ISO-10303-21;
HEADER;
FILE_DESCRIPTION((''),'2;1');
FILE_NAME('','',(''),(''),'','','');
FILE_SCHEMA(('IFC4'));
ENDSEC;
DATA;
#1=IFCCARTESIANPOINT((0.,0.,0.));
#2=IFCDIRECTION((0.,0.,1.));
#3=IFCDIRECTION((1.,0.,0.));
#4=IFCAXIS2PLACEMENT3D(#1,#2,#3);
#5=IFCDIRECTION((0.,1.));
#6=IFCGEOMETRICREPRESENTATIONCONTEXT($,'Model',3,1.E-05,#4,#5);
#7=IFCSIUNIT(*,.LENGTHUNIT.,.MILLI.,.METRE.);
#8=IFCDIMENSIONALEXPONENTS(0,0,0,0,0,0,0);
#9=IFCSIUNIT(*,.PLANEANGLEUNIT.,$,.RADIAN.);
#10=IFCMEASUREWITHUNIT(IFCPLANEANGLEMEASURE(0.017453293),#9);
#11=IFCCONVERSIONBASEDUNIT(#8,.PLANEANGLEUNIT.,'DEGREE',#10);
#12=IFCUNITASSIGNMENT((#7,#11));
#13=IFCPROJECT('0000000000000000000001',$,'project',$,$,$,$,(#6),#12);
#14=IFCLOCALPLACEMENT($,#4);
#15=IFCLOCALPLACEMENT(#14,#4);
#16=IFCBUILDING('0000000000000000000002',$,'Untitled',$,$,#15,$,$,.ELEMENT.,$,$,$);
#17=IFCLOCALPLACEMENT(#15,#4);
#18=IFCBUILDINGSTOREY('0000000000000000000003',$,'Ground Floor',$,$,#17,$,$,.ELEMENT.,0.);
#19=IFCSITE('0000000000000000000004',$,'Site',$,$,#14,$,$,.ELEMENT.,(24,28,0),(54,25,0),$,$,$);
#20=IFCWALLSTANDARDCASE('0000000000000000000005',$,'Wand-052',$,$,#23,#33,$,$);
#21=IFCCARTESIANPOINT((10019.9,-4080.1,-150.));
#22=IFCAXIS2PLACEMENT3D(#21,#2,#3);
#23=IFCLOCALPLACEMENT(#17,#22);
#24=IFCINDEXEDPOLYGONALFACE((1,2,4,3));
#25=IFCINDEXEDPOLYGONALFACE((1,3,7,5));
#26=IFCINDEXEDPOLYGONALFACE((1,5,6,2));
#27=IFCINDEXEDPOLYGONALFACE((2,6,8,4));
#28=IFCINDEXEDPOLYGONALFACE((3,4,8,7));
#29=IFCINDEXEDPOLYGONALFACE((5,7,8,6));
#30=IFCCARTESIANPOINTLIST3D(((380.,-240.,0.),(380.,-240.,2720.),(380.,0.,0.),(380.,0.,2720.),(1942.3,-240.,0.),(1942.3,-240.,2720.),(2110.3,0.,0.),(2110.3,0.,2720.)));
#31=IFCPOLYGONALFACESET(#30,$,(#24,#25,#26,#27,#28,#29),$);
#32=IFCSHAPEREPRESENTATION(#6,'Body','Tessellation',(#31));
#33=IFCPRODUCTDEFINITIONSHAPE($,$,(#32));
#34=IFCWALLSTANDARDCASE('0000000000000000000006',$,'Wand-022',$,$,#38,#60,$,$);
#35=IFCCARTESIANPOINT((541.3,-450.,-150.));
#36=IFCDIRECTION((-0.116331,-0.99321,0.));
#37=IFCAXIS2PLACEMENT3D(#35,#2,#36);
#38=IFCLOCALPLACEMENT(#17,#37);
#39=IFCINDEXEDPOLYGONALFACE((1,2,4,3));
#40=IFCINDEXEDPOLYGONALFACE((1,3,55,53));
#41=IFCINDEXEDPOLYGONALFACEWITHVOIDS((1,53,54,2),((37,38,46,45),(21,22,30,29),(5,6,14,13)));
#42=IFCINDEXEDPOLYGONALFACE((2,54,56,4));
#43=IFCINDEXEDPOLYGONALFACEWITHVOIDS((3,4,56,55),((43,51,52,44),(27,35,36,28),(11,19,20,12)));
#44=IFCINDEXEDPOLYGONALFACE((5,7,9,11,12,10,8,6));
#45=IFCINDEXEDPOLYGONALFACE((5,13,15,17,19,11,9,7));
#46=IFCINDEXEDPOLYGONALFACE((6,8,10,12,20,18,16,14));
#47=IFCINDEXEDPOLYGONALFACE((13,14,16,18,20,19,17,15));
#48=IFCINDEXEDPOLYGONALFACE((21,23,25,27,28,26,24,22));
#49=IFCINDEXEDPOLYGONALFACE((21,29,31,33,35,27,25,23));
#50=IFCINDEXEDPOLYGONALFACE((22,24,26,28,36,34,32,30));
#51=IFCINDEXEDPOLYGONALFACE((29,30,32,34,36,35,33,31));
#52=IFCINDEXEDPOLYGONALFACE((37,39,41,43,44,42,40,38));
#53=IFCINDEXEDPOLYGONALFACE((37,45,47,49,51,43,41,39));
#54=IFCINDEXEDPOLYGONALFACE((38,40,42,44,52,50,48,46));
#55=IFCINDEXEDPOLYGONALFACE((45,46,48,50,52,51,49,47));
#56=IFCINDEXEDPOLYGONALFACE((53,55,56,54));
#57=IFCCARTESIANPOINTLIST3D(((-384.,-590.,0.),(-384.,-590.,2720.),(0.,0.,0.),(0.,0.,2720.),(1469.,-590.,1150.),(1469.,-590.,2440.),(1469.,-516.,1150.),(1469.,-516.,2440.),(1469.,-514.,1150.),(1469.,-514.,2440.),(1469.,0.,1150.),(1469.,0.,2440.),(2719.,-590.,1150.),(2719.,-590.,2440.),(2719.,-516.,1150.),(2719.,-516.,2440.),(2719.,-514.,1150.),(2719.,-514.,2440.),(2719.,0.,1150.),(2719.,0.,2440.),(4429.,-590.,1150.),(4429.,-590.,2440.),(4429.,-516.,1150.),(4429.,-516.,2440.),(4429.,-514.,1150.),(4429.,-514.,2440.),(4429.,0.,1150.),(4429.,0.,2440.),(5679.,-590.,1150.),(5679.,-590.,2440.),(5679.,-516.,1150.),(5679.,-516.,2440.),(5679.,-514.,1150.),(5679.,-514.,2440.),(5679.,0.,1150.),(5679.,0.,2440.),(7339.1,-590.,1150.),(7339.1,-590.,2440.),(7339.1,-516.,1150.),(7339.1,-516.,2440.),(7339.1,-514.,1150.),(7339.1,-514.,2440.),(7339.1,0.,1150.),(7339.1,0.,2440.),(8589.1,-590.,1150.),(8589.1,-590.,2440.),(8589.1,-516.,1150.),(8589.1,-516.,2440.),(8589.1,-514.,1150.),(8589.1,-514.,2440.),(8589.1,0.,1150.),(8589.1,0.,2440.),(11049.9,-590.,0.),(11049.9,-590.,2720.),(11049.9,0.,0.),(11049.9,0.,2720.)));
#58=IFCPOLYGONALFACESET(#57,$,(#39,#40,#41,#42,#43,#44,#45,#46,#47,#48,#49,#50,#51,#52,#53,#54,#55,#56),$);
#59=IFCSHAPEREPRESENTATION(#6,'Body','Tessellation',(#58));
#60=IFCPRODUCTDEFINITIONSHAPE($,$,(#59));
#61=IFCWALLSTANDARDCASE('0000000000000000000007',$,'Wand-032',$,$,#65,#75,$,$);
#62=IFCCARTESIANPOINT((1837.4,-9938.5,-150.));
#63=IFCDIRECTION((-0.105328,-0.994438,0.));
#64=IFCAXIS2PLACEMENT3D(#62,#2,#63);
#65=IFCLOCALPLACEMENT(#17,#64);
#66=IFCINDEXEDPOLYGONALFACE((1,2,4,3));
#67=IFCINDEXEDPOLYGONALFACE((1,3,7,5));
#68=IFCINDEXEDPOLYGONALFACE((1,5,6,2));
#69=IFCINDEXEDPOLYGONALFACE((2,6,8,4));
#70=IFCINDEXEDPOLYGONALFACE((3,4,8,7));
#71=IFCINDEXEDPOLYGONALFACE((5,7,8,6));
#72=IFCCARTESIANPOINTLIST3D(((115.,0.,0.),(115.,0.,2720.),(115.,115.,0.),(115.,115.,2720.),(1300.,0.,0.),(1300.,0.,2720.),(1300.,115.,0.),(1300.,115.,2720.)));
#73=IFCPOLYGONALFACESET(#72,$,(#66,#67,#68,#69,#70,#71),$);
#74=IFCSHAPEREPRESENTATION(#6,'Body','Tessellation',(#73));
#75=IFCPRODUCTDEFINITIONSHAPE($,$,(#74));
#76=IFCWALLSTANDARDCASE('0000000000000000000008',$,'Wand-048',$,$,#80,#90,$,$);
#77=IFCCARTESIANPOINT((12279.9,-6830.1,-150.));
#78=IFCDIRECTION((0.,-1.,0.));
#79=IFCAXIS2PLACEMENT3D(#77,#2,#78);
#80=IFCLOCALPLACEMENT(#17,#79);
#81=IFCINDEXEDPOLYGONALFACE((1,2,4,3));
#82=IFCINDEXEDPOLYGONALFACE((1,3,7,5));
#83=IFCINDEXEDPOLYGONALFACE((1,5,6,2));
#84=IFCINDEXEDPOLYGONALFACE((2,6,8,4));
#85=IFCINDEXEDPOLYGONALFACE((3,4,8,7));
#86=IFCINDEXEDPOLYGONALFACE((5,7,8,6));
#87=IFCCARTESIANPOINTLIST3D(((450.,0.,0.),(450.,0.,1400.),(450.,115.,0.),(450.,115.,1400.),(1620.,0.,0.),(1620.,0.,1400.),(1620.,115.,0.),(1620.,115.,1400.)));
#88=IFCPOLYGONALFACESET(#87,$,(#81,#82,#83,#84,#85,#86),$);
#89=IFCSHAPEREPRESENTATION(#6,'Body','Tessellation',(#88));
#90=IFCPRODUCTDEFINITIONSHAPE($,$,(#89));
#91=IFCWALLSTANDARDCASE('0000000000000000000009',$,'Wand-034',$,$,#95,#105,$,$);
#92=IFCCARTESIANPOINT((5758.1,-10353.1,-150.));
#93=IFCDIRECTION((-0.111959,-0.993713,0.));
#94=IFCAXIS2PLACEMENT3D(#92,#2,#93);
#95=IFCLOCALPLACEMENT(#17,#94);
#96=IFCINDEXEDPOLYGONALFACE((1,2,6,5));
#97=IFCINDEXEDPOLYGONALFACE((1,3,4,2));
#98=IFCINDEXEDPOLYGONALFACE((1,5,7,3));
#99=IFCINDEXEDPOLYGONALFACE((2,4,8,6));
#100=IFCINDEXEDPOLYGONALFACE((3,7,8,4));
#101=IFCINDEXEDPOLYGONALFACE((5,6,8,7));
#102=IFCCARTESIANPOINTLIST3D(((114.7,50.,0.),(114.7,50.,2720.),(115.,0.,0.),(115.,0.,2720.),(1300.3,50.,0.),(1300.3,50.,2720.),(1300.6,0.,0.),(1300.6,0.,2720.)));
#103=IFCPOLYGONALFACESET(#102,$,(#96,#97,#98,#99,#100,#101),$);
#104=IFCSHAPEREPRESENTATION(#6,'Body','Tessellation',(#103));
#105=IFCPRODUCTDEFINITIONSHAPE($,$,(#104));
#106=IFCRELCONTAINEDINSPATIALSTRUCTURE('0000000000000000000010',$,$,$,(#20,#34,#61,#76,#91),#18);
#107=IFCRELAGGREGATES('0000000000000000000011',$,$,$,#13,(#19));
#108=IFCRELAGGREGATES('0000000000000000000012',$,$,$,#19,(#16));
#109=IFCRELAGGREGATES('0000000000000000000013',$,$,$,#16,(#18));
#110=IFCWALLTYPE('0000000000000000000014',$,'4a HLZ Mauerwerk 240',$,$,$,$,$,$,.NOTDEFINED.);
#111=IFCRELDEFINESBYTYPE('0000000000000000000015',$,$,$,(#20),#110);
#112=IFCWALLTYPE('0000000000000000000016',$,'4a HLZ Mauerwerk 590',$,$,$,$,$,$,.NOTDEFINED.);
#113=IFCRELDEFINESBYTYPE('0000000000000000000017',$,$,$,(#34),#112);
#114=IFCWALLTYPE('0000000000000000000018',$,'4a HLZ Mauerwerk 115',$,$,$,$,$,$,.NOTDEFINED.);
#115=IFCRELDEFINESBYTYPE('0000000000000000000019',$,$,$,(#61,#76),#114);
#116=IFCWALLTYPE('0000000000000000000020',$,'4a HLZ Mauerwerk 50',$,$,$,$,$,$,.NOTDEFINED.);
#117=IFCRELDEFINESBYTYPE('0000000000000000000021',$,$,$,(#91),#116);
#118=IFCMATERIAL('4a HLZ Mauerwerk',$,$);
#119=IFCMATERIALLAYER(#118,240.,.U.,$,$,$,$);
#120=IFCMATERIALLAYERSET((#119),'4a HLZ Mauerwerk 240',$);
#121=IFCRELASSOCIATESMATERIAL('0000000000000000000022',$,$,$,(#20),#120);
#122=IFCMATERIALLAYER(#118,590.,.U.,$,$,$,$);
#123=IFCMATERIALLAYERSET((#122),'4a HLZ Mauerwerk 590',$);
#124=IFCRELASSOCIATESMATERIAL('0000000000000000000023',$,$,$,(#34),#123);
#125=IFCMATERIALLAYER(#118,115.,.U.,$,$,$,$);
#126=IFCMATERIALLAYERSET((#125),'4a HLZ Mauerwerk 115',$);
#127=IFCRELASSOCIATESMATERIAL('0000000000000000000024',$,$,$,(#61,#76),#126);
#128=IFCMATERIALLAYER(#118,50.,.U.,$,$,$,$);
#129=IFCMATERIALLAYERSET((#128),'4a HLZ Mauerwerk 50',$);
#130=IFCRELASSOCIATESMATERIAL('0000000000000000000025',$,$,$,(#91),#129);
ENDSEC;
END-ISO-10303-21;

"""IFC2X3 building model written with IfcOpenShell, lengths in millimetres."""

from ifc_helpers import new_model, entity, si_unit, converted_unit, direction, frame, origin_with_axes, origin_2d_with_axis, place, context, project, spatial, polyline, rectangle, outline, extrude, material, layer, layer_set, layer_usage, type_object, element, save


model = new_model("IFC2X3")

# Units and contexts
model_context = context("Model", 3, precision=1e-05, world=origin_with_axes(), true_north=direction((0.0, 1.0)))
ifc_project = project(units=[si_unit("LENGTHUNIT", "METRE", prefix="MILLI"), converted_unit("PLANEANGLEUNIT", "DEGREE", entity("IfcPlaneAngleMeasure", 0.017453293), si_unit("PLANEANGLEUNIT", "RADIAN"), dimensions=[0, 0, 0, 0, 0, 0, 0])], contexts=[model_context])

# Site, building, storey
site_placement = place(None, origin_with_axes())
site = spatial("IfcSite", under=ifc_project, at=site_placement, Name="Site", CompositionType="ELEMENT", RefLatitude=(24, 28, 0), RefLongitude=(54, 25, 0))
building_placement = place(site_placement, origin_with_axes())
building = spatial("IfcBuilding", under=site, at=building_placement, Name="Untitled", CompositionType="ELEMENT")
storey_placement = place(building_placement, origin_with_axes())
storey = spatial("IfcBuildingStorey", under=building, at=storey_placement, Name="Ground Floor", CompositionType="ELEMENT", Elevation=0.0)

# Shared definitions
ifc_material_1 = material(Name="4a HLZ Mauerwerk")

# Shared definitions
ifc_layer_1 = layer(ifc_material_1, 240.0, ventilated="UNKNOWN")
ifc_layer_set_1 = layer_set([ifc_layer_1], Name="4a HLZ Mauerwerk 240")
wall_type_1 = type_object("IfcWallType", Name="4a HLZ Mauerwerk 240", PredefinedType="NOTDEFINED")

# Wall
ifc_layer_usage_1 = layer_usage(ifc_layer_set_1, "AXIS2", "NEGATIVE", 0.0)
wall_1_placement = place(storey_placement, frame((10019.9, -4080.1, -150.0), z_axis=(0.0, 0.0, 1.0), x_axis=(1.0, 0.0, 0.0)))
element("IfcWallStandardCase", 1, at=wall_1_placement, inside=storey, type_object=wall_type_1, material=ifc_layer_usage_1, Name="Wand-052", context=model_context, shape_type="SweptSolid", body=[
    extrude(outline(polyline([(380.0, -240.0), (1942.3, -240.0), (2110.3, 0.0), (380.0, 0.0), (380.0, -240.0)])), origin_with_axes(), (0.0, 0.0, 1.0), 2720.0),
])

# Wall, openings
ifc_layer_2 = layer(ifc_material_1, 590.0, ventilated="UNKNOWN")
ifc_layer_set_2 = layer_set([ifc_layer_2], Name="4a HLZ Mauerwerk 590")
ifc_layer_usage_2 = layer_usage(ifc_layer_set_2, "AXIS2", "NEGATIVE", 0.0)
wall_type_2 = type_object("IfcWallType", Name="4a HLZ Mauerwerk 590", PredefinedType="NOTDEFINED")
wall_2_placement = place(storey_placement, frame((541.3, -450.0, -150.0), z_axis=(0.0, 0.0, 1.0), x_axis=(-0.116331, -0.99321, 0.0)))
wall_2 = element("IfcWallStandardCase", 2, at=wall_2_placement, inside=storey, type_object=wall_type_2, material=ifc_layer_usage_2, Name="Wand-022", context=model_context, shape_type="SweptSolid", body=[
    extrude(outline(polyline([(-384.0, -590.0), (11049.9, -590.0), (11049.9, 0.0), (0.0, 0.0), (-384.0, -590.0)])), origin_with_axes(), (0.0, 0.0, 1.0), 2720.0),
])
opening_1_placement = place(wall_2_placement, frame((2094.0, 0.0, 1150.0), z_axis=(0.0, 0.0, 1.0), x_axis=(1.0, 0.0, 0.0)))
element("IfcOpeningElement", 3, at=opening_1_placement, cuts=wall_2, context=model_context, shape_type="SweptSolid", body=[
    extrude(rectangle(XDim=1250.0, YDim=1290.0, at=origin_2d_with_axis()), frame((0.0, -1696.0, 645.0), z_axis=(0.0, 1.0, 0.0), x_axis=(1.0, 0.0, 0.0)), (0.0, 0.0, 1.0), 1182.0),
    extrude(rectangle(XDim=1250.0, YDim=1290.0, at=origin_2d_with_axis()), frame((0.0, 666.0, 645.0), z_axis=(0.0, -1.0, 0.0), x_axis=(1.0, 0.0, 0.0)), (0.0, 0.0, 1.0), 1182.0),
])
opening_2_placement = place(wall_2_placement, frame((5054.0, 0.0, 1150.0), z_axis=(0.0, 0.0, 1.0), x_axis=(1.0, 0.0, 0.0)))
element("IfcOpeningElement", 4, at=opening_2_placement, cuts=wall_2, context=model_context, shape_type="SweptSolid", body=[
    extrude(rectangle(XDim=1250.0, YDim=1290.0, at=origin_2d_with_axis()), frame((0.0, -1696.0, 645.0), z_axis=(0.0, 1.0, 0.0), x_axis=(1.0, 0.0, 0.0)), (0.0, 0.0, 1.0), 1182.0),
    extrude(rectangle(XDim=1250.0, YDim=1290.0, at=origin_2d_with_axis()), frame((0.0, 666.0, 645.0), z_axis=(0.0, -1.0, 0.0), x_axis=(1.0, 0.0, 0.0)), (0.0, 0.0, 1.0), 1182.0),
])
opening_3_placement = place(wall_2_placement, frame((7964.1, 0.0, 1150.0), z_axis=(0.0, 0.0, 1.0), x_axis=(1.0, 0.0, 0.0)))
element("IfcOpeningElement", 5, at=opening_3_placement, cuts=wall_2, context=model_context, shape_type="SweptSolid", body=[
    extrude(rectangle(XDim=1250.0, YDim=1290.0, at=origin_2d_with_axis()), frame((0.0, -1696.0, 645.0), z_axis=(0.0, 1.0, 0.0), x_axis=(1.0, 0.0, 0.0)), (0.0, 0.0, 1.0), 1182.0),
    extrude(rectangle(XDim=1250.0, YDim=1290.0, at=origin_2d_with_axis()), frame((0.0, 666.0, 645.0), z_axis=(0.0, -1.0, 0.0), x_axis=(1.0, 0.0, 0.0)), (0.0, 0.0, 1.0), 1182.0),
])
ifc_layer_3 = layer(ifc_material_1, 115.0, ventilated="UNKNOWN")
ifc_layer_set_3 = layer_set([ifc_layer_3], Name="4a HLZ Mauerwerk 115")
wall_type_3 = type_object("IfcWallType", Name="4a HLZ Mauerwerk 115", PredefinedType="NOTDEFINED")

# Walls
ifc_layer_usage_3 = layer_usage(ifc_layer_set_3, "AXIS2", "POSITIVE", 0.0)
wall_3_placement = place(storey_placement, frame((1837.4, -9938.5, -150.0), z_axis=(0.0, 0.0, 1.0), x_axis=(-0.105328, -0.994438, 0.0)))
element("IfcWallStandardCase", 6, at=wall_3_placement, inside=storey, type_object=wall_type_3, material=ifc_layer_usage_3, Name="Wand-032", context=model_context, shape_type="SweptSolid", body=[
    extrude(outline(polyline([(115.0, 0.0), (1300.0, 0.0), (1300.0, 115.0), (115.0, 115.0), (115.0, 0.0)])), origin_with_axes(), (0.0, 0.0, 1.0), 2720.0),
])
ifc_layer_usage_4 = layer_usage(ifc_layer_set_3, "AXIS2", "POSITIVE", 0.0)
wall_4_placement = place(storey_placement, frame((12279.9, -6830.1, -150.0), z_axis=(0.0, 0.0, 1.0), x_axis=(0.0, -1.0, 0.0)))
element("IfcWallStandardCase", 7, at=wall_4_placement, inside=storey, type_object=wall_type_3, material=ifc_layer_usage_4, Name="Wand-048", context=model_context, shape_type="SweptSolid", body=[
    extrude(outline(polyline([(450.0, 0.0), (1620.0, 0.0), (1620.0, 115.0), (450.0, 115.0), (450.0, 0.0)])), origin_with_axes(), (0.0, 0.0, 1.0), 1400.0),
])
ifc_layer_4 = layer(ifc_material_1, 50.0, ventilated="UNKNOWN")
ifc_layer_set_4 = layer_set([ifc_layer_4], Name="4a HLZ Mauerwerk 50")
ifc_layer_usage_5 = layer_usage(ifc_layer_set_4, "AXIS2", "POSITIVE", 0.0)
wall_type_4 = type_object("IfcWallType", Name="4a HLZ Mauerwerk 50", PredefinedType="NOTDEFINED")
wall_5_placement = place(storey_placement, frame((5758.1, -10353.1, -150.0), z_axis=(0.0, 0.0, 1.0), x_axis=(-0.111959, -0.993713, 0.0)))
element("IfcWallStandardCase", 8, at=wall_5_placement, inside=storey, type_object=wall_type_4, material=ifc_layer_usage_5, Name="Wand-034", context=model_context, shape_type="SweptSolid", body=[
    extrude(outline(polyline([(115.0, 0.0), (1300.6, 0.0), (1300.3, 50.0), (114.7, 50.0), (115.0, 0.0)])), origin_with_axes(), (0.0, 0.0, 1.0), 2720.0),
])

save(model, "model.ifc")
